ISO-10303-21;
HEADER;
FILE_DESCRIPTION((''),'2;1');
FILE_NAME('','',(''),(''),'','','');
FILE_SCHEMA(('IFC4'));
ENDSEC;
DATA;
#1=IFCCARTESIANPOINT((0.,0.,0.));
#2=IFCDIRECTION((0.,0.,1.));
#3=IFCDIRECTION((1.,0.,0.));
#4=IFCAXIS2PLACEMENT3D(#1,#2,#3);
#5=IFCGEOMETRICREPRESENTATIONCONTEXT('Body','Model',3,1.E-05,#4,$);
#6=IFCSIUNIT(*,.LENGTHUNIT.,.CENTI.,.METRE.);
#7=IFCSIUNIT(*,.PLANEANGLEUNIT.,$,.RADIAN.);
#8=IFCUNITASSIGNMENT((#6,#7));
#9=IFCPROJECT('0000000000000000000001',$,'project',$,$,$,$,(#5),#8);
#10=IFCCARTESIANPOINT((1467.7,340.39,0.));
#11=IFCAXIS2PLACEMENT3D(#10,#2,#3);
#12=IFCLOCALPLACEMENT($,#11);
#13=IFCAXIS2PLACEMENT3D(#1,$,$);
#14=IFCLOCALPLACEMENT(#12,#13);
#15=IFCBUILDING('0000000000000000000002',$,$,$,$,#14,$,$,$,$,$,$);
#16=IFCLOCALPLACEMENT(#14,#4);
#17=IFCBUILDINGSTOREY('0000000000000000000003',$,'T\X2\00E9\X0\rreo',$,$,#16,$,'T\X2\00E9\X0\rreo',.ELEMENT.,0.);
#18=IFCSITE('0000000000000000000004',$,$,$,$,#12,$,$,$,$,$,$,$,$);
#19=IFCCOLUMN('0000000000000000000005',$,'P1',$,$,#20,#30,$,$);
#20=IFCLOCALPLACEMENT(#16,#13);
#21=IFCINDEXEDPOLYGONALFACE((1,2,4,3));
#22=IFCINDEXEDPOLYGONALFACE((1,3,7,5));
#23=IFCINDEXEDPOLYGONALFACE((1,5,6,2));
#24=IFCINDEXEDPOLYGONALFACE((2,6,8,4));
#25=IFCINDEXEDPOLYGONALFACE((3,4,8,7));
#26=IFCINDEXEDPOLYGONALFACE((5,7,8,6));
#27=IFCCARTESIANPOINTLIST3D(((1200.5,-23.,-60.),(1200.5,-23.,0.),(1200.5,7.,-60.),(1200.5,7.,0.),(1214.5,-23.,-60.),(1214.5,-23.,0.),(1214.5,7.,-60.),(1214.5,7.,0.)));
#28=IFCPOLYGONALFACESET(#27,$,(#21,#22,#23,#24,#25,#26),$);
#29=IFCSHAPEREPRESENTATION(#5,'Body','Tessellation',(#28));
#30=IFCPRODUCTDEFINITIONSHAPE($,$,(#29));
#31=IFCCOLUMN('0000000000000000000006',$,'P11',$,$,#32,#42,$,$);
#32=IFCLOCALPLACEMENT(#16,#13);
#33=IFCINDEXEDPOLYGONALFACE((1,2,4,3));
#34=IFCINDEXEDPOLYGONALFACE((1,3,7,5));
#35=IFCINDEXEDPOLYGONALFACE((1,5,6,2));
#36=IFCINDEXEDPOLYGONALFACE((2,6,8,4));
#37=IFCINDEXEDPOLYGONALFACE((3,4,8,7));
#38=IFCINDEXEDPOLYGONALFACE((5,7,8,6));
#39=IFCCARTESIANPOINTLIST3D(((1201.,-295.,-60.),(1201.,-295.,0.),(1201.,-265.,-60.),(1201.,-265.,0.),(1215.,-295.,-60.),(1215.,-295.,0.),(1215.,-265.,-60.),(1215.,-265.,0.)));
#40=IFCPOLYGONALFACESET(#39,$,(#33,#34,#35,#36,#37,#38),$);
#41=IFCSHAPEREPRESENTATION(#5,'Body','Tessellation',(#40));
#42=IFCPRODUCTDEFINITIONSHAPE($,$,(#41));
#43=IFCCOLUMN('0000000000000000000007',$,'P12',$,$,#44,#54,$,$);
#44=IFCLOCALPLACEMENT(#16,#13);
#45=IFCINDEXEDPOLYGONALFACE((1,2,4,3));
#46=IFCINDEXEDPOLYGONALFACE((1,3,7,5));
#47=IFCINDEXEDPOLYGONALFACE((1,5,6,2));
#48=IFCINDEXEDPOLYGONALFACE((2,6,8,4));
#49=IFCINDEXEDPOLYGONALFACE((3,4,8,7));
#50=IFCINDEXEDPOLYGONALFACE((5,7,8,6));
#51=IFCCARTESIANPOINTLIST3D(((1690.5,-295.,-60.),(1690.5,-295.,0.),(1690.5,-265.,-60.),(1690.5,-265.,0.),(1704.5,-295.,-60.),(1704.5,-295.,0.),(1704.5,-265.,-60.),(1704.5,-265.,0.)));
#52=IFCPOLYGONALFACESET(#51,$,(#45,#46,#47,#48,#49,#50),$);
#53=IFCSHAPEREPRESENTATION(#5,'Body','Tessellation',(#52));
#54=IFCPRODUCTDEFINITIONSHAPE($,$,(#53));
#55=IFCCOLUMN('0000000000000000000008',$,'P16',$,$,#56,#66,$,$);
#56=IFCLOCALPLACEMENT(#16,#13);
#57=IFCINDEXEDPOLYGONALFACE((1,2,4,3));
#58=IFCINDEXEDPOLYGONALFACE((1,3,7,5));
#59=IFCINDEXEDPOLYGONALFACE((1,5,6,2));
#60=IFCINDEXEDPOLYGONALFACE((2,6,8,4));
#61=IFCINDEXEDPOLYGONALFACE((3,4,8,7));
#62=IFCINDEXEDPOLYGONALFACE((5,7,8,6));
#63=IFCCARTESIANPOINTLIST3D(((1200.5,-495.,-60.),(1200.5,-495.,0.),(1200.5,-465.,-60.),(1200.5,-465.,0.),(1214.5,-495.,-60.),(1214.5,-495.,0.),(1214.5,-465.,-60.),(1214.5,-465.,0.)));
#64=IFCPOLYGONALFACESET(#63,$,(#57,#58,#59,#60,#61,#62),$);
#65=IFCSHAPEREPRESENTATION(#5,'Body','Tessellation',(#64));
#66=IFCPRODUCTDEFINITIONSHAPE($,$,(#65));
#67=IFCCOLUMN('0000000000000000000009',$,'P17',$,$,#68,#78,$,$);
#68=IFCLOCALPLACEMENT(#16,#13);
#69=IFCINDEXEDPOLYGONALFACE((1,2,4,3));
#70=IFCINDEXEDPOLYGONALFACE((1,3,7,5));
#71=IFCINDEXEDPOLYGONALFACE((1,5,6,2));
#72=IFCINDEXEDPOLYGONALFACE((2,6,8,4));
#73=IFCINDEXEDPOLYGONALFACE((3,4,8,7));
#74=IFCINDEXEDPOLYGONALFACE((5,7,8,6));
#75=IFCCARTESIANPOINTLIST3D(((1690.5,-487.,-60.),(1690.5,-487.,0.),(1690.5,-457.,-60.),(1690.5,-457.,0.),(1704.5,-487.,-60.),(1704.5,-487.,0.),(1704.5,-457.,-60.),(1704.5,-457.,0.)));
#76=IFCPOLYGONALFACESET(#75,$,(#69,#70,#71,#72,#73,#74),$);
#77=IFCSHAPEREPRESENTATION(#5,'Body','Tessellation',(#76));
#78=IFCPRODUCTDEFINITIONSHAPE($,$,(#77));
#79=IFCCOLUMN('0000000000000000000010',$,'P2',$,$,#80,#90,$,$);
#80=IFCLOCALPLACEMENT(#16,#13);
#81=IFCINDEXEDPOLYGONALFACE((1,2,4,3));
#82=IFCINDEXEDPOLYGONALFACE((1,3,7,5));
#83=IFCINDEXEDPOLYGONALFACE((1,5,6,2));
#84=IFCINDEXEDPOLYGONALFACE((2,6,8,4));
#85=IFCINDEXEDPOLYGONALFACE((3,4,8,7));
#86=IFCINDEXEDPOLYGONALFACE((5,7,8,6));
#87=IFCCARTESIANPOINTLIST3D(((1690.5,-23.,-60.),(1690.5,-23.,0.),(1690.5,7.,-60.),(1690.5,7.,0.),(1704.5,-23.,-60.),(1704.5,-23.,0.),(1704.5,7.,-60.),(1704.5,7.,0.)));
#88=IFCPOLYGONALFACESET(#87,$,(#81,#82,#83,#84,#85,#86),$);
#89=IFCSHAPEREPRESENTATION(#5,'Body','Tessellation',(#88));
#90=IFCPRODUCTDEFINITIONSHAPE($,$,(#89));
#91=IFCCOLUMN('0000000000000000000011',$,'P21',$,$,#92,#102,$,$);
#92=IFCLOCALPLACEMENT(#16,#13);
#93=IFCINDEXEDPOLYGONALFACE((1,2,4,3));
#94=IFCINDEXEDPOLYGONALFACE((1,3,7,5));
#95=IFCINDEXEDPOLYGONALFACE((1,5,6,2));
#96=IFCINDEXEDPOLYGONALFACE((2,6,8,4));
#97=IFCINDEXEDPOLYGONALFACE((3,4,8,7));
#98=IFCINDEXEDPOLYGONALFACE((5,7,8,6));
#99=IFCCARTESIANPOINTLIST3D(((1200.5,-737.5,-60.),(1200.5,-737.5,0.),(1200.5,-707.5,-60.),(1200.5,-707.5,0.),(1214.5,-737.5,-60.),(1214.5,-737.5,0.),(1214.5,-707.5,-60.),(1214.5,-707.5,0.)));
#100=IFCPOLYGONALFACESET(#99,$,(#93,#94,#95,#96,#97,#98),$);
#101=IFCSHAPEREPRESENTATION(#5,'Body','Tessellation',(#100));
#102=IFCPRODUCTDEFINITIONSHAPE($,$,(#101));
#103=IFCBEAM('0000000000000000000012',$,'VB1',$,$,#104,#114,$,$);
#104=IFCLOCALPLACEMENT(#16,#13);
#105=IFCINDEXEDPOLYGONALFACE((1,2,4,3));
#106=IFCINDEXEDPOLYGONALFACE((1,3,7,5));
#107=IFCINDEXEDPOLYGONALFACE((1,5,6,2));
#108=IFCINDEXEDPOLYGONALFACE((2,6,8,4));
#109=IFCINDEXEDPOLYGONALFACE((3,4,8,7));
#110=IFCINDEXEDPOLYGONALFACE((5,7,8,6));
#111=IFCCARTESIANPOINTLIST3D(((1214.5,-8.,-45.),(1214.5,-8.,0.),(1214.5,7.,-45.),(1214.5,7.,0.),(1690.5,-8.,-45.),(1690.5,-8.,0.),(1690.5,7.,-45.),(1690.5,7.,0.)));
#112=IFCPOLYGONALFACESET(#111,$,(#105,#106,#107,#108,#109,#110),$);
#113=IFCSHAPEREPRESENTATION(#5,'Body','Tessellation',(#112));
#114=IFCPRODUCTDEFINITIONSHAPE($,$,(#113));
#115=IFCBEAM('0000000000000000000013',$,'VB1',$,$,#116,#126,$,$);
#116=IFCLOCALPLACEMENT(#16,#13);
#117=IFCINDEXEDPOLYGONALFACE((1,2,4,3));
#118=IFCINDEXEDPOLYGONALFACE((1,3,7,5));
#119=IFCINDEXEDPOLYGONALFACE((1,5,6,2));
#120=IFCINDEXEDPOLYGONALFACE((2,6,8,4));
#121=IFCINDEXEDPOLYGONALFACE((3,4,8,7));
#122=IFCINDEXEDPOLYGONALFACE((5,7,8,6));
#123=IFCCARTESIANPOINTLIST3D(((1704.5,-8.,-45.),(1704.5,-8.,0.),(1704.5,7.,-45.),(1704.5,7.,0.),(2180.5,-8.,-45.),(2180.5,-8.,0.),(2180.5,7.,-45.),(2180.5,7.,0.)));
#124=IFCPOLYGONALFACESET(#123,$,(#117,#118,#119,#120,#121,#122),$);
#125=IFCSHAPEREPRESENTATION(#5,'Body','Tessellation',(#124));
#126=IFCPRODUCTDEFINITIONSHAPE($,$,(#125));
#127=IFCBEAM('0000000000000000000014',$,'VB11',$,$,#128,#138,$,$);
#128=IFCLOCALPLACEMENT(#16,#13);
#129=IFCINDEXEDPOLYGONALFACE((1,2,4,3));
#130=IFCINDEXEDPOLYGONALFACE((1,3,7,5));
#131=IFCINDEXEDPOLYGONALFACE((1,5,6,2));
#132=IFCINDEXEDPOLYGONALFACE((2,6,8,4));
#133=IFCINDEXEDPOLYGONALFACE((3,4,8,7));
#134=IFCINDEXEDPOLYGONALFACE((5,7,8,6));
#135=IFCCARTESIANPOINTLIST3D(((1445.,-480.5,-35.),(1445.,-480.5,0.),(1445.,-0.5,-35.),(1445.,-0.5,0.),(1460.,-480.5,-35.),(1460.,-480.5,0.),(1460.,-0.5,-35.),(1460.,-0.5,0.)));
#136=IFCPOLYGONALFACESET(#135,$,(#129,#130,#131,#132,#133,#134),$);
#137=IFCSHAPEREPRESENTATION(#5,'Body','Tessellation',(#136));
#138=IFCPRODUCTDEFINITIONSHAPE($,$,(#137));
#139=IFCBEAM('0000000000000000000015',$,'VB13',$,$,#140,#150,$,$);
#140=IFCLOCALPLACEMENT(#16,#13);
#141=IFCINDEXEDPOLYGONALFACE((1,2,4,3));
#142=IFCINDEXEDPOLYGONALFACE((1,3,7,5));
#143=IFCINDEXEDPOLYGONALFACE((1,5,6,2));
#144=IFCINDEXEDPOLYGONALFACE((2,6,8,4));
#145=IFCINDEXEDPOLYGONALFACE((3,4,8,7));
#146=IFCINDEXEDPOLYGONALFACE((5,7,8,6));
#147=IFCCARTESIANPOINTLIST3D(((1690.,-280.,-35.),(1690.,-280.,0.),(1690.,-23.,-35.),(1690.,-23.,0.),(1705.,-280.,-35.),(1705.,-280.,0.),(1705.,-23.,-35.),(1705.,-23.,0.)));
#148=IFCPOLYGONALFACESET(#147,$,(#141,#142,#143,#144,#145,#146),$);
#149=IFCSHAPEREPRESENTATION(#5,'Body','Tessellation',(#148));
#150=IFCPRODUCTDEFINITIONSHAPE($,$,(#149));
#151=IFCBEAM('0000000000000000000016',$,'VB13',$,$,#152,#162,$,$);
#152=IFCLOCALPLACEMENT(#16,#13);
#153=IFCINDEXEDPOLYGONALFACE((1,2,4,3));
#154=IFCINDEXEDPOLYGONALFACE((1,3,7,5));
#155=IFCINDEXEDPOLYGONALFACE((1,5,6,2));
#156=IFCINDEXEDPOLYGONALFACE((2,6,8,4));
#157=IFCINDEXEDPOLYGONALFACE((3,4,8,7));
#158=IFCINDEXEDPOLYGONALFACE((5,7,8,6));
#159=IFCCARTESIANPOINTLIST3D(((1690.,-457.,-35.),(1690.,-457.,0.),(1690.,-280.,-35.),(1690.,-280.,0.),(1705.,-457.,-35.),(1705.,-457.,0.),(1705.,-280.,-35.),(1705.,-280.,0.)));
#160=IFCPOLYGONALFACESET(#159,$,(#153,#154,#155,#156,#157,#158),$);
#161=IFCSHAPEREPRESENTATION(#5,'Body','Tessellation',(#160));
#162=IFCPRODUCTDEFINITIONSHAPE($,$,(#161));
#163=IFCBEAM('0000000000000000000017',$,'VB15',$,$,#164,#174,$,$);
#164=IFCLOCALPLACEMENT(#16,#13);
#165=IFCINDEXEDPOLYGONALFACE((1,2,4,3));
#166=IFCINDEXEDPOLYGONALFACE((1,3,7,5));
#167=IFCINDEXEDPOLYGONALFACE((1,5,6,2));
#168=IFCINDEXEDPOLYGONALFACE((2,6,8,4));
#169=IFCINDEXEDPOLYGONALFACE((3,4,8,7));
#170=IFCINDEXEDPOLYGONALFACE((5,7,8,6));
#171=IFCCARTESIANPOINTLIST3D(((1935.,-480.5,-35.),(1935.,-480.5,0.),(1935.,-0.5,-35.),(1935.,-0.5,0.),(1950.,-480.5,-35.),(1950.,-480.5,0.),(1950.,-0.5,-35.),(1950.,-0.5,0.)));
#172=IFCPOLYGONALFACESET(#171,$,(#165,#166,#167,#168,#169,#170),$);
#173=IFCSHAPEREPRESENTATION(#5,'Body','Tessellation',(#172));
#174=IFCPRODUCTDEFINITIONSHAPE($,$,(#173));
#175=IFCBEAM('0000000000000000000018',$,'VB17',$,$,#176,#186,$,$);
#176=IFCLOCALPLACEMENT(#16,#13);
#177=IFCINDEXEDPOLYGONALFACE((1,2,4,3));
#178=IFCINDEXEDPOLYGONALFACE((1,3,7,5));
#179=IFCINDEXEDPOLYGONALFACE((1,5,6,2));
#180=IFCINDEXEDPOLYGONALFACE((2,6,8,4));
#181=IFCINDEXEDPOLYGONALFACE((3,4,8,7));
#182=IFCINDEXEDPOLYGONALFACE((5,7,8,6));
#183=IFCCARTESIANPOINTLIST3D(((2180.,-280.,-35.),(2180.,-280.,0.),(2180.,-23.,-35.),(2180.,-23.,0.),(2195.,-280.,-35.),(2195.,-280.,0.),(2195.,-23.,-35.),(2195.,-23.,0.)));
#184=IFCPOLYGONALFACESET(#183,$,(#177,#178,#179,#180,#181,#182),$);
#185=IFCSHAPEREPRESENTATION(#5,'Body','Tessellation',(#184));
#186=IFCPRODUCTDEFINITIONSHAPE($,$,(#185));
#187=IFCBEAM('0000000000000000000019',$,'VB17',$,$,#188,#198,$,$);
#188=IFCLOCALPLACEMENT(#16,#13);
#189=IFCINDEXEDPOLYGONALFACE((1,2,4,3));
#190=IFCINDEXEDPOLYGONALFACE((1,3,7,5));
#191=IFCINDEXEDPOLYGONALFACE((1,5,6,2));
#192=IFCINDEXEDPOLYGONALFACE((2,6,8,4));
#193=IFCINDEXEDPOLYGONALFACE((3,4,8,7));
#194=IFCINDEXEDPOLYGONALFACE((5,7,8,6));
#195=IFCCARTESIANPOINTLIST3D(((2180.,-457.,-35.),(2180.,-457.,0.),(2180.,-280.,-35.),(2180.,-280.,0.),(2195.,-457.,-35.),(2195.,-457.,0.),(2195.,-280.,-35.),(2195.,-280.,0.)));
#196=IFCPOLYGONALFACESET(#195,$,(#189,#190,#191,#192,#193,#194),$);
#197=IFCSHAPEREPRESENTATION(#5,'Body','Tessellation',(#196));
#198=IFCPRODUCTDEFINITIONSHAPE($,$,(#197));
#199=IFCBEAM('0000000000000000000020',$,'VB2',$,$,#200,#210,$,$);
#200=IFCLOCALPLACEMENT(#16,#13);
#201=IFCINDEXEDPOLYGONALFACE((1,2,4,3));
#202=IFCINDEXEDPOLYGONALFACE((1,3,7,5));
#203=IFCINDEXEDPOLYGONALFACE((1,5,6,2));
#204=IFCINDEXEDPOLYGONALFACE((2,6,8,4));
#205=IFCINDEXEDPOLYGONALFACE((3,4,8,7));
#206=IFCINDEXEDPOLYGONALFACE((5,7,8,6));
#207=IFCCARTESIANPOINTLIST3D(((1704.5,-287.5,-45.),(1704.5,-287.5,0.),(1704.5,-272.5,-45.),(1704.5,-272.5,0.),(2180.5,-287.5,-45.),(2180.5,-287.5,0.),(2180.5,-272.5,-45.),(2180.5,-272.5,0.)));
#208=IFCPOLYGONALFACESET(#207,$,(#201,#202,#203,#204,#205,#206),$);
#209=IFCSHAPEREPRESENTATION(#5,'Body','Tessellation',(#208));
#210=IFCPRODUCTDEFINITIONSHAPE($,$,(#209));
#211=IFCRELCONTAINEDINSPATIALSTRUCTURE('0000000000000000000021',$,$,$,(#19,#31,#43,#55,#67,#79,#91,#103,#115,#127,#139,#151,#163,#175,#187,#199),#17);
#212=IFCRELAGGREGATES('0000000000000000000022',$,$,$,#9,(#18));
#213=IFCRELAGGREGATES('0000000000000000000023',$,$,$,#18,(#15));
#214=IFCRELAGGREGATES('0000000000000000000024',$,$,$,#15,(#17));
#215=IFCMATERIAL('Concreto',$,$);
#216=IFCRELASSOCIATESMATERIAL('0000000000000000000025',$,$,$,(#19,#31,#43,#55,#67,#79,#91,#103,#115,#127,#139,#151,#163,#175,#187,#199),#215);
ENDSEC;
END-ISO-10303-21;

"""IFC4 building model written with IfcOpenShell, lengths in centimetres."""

from ifc_helpers import new_model, si_unit, frame, origin, origin_with_axes, origin_2d_with_axis, place, context, project, spatial, rectangle, extrude, material, element, save


model = new_model("IFC4")

# Units and contexts
model_context = context("Model", 3, precision=1e-05, world=origin_with_axes(), identifier="Body")
ifc_project = project(units=[si_unit("LENGTHUNIT", "METRE", prefix="CENTI"), si_unit("PLANEANGLEUNIT", "RADIAN")], contexts=[model_context])

# Site, building, storey
site_placement = place(None, frame((1467.7, 340.39, 0.0), z_axis=(0.0, 0.0, 1.0), x_axis=(1.0, 0.0, 0.0)))
site = spatial("IfcSite", under=ifc_project, at=site_placement)
building_placement = place(site_placement, origin())
building = spatial("IfcBuilding", under=site, at=building_placement)
storey_placement = place(building_placement, origin_with_axes())
storey = spatial("IfcBuildingStorey", under=building, at=storey_placement, Name="Térreo", LongName="Térreo", CompositionType="ELEMENT", Elevation=0.0)

# Columns
ifc_material = material(Name="Concreto")
for number, where, z_axis, x_axis, name in (
    (1, (1207.5, -8.0, 0.0), (0.0, 0.0, 1.0), (1.0, 0.0, 0.0), "P1"),
    (2, (1208.0, -280.0, 0.0), (0.0, 0.0, 1.0), (1.0, 0.0, 0.0), "P11"),
    (3, (1697.5, -280.0, 0.0), (0.0, 0.0, 1.0), (1.0, 0.0, 0.0), "P12"),
    (4, (1207.5, -480.0, 0.0), (0.0, 0.0, 1.0), (1.0, 0.0, 0.0), "P16"),
):
    element("IfcColumn", number, at=place(storey_placement, frame(where, z_axis=z_axis, x_axis=x_axis)), inside=storey, material=ifc_material, Name=name, context=model_context, shape_type="SolidModel", body=[
        extrude(rectangle(XDim=14.0, YDim=30.0, at=origin_2d_with_axis()), frame((0.0, 0.0, -60.0), z_axis=(0.0, 0.0, 1.0), x_axis=(1.0, 0.0, 0.0)), (0.0, 0.0, 1.0), 60.0),
    ])
column_placement = place(storey_placement, frame((1697.5, -472.0, 0.0), z_axis=(0.0, 0.0, 1.0), x_axis=(1.0, 0.0, 0.0)))
element("IfcColumn", 5, at=column_placement, inside=storey, material=ifc_material, Name="P17", context=model_context, shape_type="SolidModel", body=[
    extrude(rectangle(XDim=14.0, YDim=30.0, at=origin_2d_with_axis()), frame((0.0, 0.0, -60.0), z_axis=(0.0, 0.0, 1.0), x_axis=(-1.0, 0.0, 0.0)), (0.0, 0.0, 1.0), 60.0),
])
for number, where, z_axis, x_axis, name in (
    (6, (1697.5, -8.0, 0.0), (0.0, 0.0, 1.0), (1.0, 0.0, 0.0), "P2"),
    (7, (1207.5, -722.5, 0.0), (0.0, 0.0, 1.0), (1.0, 0.0, 0.0), "P21"),
):
    element("IfcColumn", number, at=place(storey_placement, frame(where, z_axis=z_axis, x_axis=x_axis)), inside=storey, material=ifc_material, Name=name, context=model_context, shape_type="SolidModel", body=[
        extrude(rectangle(XDim=14.0, YDim=30.0, at=origin_2d_with_axis()), frame((0.0, 0.0, -60.0), z_axis=(0.0, 0.0, 1.0), x_axis=(1.0, 0.0, 0.0)), (0.0, 0.0, 1.0), 60.0),
    ])

# Beams
for number, where, z_axis, x_axis, name in (
    (8, (1452.5, -0.5, 0.0), (0.0, 0.0, 1.0), (1.0, 0.0, 0.0), "VB1"),
    (9, (1942.5, -0.5, 0.0), (0.0, 0.0, 1.0), (1.0, 0.0, 0.0), "VB1"),
):
    element("IfcBeam", number, at=place(storey_placement, frame(where, z_axis=z_axis, x_axis=x_axis)), inside=storey, material=ifc_material, Name=name, context=model_context, shape_type="SolidModel", body=[
        extrude(rectangle(XDim=15.0, YDim=45.0, at=origin_2d_with_axis()), frame((-238.0, 0.0, -22.5), z_axis=(1.0, 0.0, 0.0), x_axis=(0.0, 1.0, 0.0)), (0.0, 0.0, 1.0), 476.0),
    ])
beam_1_placement = place(storey_placement, frame((1452.5, -240.5, 0.0), z_axis=(0.0, 0.0, 1.0), x_axis=(1.0, 0.0, 0.0)))
element("IfcBeam", 10, at=beam_1_placement, inside=storey, material=ifc_material, Name="VB11", context=model_context, shape_type="SolidModel", body=[
    extrude(rectangle(XDim=15.0, YDim=35.0, at=origin_2d_with_axis()), frame((0.0, -240.0, -17.5), z_axis=(0.0, 1.0, 0.0), x_axis=(1.0, 0.0, 0.0)), (0.0, 0.0, 1.0), 480.0),
])
beam_2_placement = place(storey_placement, frame((1697.5, -151.5, 0.0), z_axis=(0.0, 0.0, 1.0), x_axis=(1.0, 0.0, 0.0)))
element("IfcBeam", 11, at=beam_2_placement, inside=storey, material=ifc_material, Name="VB13", context=model_context, shape_type="SolidModel", body=[
    extrude(rectangle(XDim=15.0, YDim=35.0, at=origin_2d_with_axis()), frame((0.0, -128.5, -17.5), z_axis=(0.0, 1.0, 0.0), x_axis=(1.0, 0.0, 0.0)), (0.0, 0.0, 1.0), 257.0),
])
beam_3_placement = place(storey_placement, frame((1697.5, -368.5, 0.0), z_axis=(0.0, 0.0, 1.0), x_axis=(1.0, 0.0, 0.0)))
element("IfcBeam", 12, at=beam_3_placement, inside=storey, material=ifc_material, Name="VB13", context=model_context, shape_type="SolidModel", body=[
    extrude(rectangle(XDim=15.0, YDim=35.0, at=origin_2d_with_axis()), frame((0.0, -88.5, -17.5), z_axis=(0.0, 1.0, 0.0), x_axis=(1.0, 0.0, 0.0)), (0.0, 0.0, 1.0), 177.0),
])
beam_4_placement = place(storey_placement, frame((1942.5, -240.5, 0.0), z_axis=(0.0, 0.0, 1.0), x_axis=(1.0, 0.0, 0.0)))
element("IfcBeam", 13, at=beam_4_placement, inside=storey, material=ifc_material, Name="VB15", context=model_context, shape_type="SolidModel", body=[
    extrude(rectangle(XDim=15.0, YDim=35.0, at=origin_2d_with_axis()), frame((0.0, -240.0, -17.5), z_axis=(0.0, 1.0, 0.0), x_axis=(1.0, 0.0, 0.0)), (0.0, 0.0, 1.0), 480.0),
])
beam_5_placement = place(storey_placement, frame((2187.5, -151.5, 0.0), z_axis=(0.0, 0.0, 1.0), x_axis=(1.0, 0.0, 0.0)))
element("IfcBeam", 14, at=beam_5_placement, inside=storey, material=ifc_material, Name="VB17", context=model_context, shape_type="SolidModel", body=[
    extrude(rectangle(XDim=15.0, YDim=35.0, at=origin_2d_with_axis()), frame((0.0, -128.5, -17.5), z_axis=(0.0, 1.0, 0.0), x_axis=(1.0, 0.0, 0.0)), (0.0, 0.0, 1.0), 257.0),
])
beam_6_placement = place(storey_placement, frame((2187.5, -368.5, 0.0), z_axis=(0.0, 0.0, 1.0), x_axis=(1.0, 0.0, 0.0)))
element("IfcBeam", 15, at=beam_6_placement, inside=storey, material=ifc_material, Name="VB17", context=model_context, shape_type="SolidModel", body=[
    extrude(rectangle(XDim=15.0, YDim=35.0, at=origin_2d_with_axis()), frame((0.0, -88.5, -17.5), z_axis=(0.0, 1.0, 0.0), x_axis=(1.0, 0.0, 0.0)), (0.0, 0.0, 1.0), 177.0),
])
beam_7_placement = place(storey_placement, frame((1942.5, -280.0, 0.0), z_axis=(0.0, 0.0, 1.0), x_axis=(1.0, 0.0, 0.0)))
element("IfcBeam", 16, at=beam_7_placement, inside=storey, material=ifc_material, Name="VB2", context=model_context, shape_type="SolidModel", body=[
    extrude(rectangle(XDim=15.0, YDim=45.0, at=origin_2d_with_axis()), frame((-238.0, 0.0, -22.5), z_axis=(1.0, 0.0, 0.0), x_axis=(0.0, 1.0, 0.0)), (0.0, 0.0, 1.0), 476.0),
])

save(model, "model.ifc")
